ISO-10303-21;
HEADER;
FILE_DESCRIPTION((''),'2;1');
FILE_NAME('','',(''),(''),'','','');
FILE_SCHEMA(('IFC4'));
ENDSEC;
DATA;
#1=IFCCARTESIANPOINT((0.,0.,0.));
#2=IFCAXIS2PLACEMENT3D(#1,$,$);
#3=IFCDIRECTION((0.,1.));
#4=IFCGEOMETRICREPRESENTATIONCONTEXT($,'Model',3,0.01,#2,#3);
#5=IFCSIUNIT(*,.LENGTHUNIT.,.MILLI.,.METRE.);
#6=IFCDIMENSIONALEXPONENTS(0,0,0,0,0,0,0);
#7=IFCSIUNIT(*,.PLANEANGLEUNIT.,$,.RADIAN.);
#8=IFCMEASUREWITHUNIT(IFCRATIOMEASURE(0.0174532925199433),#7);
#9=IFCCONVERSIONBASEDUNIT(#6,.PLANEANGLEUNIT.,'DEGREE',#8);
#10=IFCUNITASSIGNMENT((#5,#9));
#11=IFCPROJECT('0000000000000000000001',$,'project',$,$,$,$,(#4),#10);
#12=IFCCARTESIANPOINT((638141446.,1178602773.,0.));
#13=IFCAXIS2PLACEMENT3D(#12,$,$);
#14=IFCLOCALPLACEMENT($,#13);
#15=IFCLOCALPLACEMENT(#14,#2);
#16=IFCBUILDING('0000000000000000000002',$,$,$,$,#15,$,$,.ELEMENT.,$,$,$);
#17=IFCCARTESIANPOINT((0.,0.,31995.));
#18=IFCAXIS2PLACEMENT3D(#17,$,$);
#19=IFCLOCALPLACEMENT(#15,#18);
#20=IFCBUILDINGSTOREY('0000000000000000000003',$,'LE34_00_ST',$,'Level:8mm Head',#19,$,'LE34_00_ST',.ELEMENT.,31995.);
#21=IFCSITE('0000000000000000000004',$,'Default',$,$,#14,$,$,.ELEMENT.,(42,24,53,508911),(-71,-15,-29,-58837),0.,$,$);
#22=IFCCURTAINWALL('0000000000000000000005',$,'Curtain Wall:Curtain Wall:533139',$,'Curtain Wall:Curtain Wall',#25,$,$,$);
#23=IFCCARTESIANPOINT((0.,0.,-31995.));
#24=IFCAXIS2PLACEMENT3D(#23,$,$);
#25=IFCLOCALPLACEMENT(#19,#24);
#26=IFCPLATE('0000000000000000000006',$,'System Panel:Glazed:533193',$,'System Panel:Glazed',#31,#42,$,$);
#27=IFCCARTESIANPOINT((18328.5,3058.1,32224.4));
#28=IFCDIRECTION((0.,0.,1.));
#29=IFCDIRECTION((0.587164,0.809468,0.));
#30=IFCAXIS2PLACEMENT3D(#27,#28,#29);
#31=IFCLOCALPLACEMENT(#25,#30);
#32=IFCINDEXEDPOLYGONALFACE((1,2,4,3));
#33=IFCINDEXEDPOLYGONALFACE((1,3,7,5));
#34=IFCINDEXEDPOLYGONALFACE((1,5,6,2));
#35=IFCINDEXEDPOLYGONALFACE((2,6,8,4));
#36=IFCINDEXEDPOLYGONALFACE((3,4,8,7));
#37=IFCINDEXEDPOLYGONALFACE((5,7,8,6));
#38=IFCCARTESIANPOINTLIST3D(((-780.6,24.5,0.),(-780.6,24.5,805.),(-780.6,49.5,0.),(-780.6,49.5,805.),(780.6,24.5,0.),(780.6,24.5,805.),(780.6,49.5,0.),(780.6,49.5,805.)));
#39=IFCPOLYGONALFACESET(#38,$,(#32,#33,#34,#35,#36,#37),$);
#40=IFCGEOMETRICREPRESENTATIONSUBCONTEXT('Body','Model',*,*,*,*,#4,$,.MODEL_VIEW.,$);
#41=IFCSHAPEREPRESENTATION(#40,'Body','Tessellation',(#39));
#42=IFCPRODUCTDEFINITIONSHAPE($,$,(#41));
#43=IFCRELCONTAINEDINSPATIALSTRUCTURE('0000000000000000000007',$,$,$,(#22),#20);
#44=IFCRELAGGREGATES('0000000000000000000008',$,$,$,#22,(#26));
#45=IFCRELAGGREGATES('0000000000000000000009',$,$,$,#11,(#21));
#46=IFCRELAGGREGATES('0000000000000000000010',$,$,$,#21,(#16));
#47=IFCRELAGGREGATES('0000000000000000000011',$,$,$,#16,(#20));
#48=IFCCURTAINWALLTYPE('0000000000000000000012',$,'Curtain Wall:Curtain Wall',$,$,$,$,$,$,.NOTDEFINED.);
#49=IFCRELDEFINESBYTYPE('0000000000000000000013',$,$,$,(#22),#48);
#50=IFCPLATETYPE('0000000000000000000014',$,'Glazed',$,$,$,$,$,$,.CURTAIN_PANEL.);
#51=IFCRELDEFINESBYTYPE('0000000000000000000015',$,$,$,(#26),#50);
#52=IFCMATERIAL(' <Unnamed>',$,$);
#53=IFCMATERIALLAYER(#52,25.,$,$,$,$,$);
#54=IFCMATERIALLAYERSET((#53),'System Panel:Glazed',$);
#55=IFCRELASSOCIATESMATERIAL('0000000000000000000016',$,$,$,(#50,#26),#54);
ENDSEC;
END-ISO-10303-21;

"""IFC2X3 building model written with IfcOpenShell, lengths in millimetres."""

from ifc_helpers import new_model, entity, si_unit, converted_unit, direction, frame, origin, origin_2d_with_axis, place, context, subcontext, project, spatial, rectangle, extrude, source, transform, mapped, material, layer, layer_set, layer_usage, type_object, type_shapes, element, aggregate, save


model = new_model("IFC2X3")

# Units and contexts
model_context = context("Model", 3, precision=0.01, world=origin(), true_north=direction((0.0, 1.0)))
body_context = subcontext(model_context, "Body", "Model", "MODEL_VIEW")
ifc_project = project(units=[si_unit("LENGTHUNIT", "METRE", prefix="MILLI"), converted_unit("PLANEANGLEUNIT", "DEGREE", entity("IfcRatioMeasure", 0.0174532925199433), si_unit("PLANEANGLEUNIT", "RADIAN"), dimensions=[0, 0, 0, 0, 0, 0, 0])], contexts=[model_context])

# Site, building, storey
site_placement = place(None, frame((638141446.0, 1178602773.0, 0.0)))
site = spatial("IfcSite", under=ifc_project, at=site_placement, Name="Default", CompositionType="ELEMENT", RefLatitude=(42, 24, 53, 508911), RefLongitude=(-71, -15, -29, -58837), RefElevation=0.0)
building_placement = place(site_placement, origin())
building = spatial("IfcBuilding", under=site, at=building_placement, CompositionType="ELEMENT")
storey_placement = place(building_placement, frame((0.0, 0.0, 31995.0)))
storey = spatial("IfcBuildingStorey", under=building, at=storey_placement, Name="LE34_00_ST", ObjectType="Level:8mm Head", LongName="LE34_00_ST", CompositionType="ELEMENT", Elevation=31995.0)

# Curtain wall
curtain_wall_type = type_object("IfcCurtainWallType", Name="Curtain Wall:Curtain Wall", PredefinedType="NOTDEFINED")
curtain_wall_1_placement = place(storey_placement, frame((0.0, 0.0, -31995.0)))
curtain_wall_1 = element("IfcCurtainWall", 1, at=curtain_wall_1_placement, inside=storey, type_object=curtain_wall_type, Name="Curtain Wall:Curtain Wall:533139", ObjectType="Curtain Wall:Curtain Wall")

# Plate
ifc_material_1 = material(Name=" <Unnamed>")
ifc_layer_1 = layer(ifc_material_1, 25.0)
ifc_layer_set_1 = layer_set([ifc_layer_1], Name="System Panel:Glazed")
ifc_layer_usage_1 = layer_usage(ifc_layer_set_1, "AXIS3", "POSITIVE", 0.1)
plate_type = type_object("IfcPlateType", Name="Glazed", PredefinedType="CURTAIN_PANEL", material=ifc_layer_set_1)
shared_shape_1 = source(origin(), body_context, "Body", "SweptSolid", [
    extrude(rectangle(XDim=25.0, YDim=1561.3, at=origin_2d_with_axis()), frame((0.0, 37.0, 0.0), z_axis=(0.0, 0.0, 1.0), x_axis=(0.0, 1.0, 0.0)), (0.0, 0.0, 1.0), 805.0),
])
type_shapes(plate_type, [shared_shape_1])
plate_placement = place(curtain_wall_1_placement, frame((18328.5, 3058.1, 32224.4), z_axis=(0.0, 0.0, 1.0), x_axis=(0.587164, 0.809468, 0.0)))
plate = element("IfcPlate", 2, at=plate_placement, type_object=plate_type, material=ifc_layer_usage_1, Name="System Panel:Glazed:533193", ObjectType="System Panel:Glazed", context=body_context, shape_type="MappedRepresentation", body=[
    mapped(shared_shape_1, transform((0.0, 0.0, 0.0), scale=1.0)),
])
aggregate(curtain_wall_1, [plate])

save(model, "model.ifc")
